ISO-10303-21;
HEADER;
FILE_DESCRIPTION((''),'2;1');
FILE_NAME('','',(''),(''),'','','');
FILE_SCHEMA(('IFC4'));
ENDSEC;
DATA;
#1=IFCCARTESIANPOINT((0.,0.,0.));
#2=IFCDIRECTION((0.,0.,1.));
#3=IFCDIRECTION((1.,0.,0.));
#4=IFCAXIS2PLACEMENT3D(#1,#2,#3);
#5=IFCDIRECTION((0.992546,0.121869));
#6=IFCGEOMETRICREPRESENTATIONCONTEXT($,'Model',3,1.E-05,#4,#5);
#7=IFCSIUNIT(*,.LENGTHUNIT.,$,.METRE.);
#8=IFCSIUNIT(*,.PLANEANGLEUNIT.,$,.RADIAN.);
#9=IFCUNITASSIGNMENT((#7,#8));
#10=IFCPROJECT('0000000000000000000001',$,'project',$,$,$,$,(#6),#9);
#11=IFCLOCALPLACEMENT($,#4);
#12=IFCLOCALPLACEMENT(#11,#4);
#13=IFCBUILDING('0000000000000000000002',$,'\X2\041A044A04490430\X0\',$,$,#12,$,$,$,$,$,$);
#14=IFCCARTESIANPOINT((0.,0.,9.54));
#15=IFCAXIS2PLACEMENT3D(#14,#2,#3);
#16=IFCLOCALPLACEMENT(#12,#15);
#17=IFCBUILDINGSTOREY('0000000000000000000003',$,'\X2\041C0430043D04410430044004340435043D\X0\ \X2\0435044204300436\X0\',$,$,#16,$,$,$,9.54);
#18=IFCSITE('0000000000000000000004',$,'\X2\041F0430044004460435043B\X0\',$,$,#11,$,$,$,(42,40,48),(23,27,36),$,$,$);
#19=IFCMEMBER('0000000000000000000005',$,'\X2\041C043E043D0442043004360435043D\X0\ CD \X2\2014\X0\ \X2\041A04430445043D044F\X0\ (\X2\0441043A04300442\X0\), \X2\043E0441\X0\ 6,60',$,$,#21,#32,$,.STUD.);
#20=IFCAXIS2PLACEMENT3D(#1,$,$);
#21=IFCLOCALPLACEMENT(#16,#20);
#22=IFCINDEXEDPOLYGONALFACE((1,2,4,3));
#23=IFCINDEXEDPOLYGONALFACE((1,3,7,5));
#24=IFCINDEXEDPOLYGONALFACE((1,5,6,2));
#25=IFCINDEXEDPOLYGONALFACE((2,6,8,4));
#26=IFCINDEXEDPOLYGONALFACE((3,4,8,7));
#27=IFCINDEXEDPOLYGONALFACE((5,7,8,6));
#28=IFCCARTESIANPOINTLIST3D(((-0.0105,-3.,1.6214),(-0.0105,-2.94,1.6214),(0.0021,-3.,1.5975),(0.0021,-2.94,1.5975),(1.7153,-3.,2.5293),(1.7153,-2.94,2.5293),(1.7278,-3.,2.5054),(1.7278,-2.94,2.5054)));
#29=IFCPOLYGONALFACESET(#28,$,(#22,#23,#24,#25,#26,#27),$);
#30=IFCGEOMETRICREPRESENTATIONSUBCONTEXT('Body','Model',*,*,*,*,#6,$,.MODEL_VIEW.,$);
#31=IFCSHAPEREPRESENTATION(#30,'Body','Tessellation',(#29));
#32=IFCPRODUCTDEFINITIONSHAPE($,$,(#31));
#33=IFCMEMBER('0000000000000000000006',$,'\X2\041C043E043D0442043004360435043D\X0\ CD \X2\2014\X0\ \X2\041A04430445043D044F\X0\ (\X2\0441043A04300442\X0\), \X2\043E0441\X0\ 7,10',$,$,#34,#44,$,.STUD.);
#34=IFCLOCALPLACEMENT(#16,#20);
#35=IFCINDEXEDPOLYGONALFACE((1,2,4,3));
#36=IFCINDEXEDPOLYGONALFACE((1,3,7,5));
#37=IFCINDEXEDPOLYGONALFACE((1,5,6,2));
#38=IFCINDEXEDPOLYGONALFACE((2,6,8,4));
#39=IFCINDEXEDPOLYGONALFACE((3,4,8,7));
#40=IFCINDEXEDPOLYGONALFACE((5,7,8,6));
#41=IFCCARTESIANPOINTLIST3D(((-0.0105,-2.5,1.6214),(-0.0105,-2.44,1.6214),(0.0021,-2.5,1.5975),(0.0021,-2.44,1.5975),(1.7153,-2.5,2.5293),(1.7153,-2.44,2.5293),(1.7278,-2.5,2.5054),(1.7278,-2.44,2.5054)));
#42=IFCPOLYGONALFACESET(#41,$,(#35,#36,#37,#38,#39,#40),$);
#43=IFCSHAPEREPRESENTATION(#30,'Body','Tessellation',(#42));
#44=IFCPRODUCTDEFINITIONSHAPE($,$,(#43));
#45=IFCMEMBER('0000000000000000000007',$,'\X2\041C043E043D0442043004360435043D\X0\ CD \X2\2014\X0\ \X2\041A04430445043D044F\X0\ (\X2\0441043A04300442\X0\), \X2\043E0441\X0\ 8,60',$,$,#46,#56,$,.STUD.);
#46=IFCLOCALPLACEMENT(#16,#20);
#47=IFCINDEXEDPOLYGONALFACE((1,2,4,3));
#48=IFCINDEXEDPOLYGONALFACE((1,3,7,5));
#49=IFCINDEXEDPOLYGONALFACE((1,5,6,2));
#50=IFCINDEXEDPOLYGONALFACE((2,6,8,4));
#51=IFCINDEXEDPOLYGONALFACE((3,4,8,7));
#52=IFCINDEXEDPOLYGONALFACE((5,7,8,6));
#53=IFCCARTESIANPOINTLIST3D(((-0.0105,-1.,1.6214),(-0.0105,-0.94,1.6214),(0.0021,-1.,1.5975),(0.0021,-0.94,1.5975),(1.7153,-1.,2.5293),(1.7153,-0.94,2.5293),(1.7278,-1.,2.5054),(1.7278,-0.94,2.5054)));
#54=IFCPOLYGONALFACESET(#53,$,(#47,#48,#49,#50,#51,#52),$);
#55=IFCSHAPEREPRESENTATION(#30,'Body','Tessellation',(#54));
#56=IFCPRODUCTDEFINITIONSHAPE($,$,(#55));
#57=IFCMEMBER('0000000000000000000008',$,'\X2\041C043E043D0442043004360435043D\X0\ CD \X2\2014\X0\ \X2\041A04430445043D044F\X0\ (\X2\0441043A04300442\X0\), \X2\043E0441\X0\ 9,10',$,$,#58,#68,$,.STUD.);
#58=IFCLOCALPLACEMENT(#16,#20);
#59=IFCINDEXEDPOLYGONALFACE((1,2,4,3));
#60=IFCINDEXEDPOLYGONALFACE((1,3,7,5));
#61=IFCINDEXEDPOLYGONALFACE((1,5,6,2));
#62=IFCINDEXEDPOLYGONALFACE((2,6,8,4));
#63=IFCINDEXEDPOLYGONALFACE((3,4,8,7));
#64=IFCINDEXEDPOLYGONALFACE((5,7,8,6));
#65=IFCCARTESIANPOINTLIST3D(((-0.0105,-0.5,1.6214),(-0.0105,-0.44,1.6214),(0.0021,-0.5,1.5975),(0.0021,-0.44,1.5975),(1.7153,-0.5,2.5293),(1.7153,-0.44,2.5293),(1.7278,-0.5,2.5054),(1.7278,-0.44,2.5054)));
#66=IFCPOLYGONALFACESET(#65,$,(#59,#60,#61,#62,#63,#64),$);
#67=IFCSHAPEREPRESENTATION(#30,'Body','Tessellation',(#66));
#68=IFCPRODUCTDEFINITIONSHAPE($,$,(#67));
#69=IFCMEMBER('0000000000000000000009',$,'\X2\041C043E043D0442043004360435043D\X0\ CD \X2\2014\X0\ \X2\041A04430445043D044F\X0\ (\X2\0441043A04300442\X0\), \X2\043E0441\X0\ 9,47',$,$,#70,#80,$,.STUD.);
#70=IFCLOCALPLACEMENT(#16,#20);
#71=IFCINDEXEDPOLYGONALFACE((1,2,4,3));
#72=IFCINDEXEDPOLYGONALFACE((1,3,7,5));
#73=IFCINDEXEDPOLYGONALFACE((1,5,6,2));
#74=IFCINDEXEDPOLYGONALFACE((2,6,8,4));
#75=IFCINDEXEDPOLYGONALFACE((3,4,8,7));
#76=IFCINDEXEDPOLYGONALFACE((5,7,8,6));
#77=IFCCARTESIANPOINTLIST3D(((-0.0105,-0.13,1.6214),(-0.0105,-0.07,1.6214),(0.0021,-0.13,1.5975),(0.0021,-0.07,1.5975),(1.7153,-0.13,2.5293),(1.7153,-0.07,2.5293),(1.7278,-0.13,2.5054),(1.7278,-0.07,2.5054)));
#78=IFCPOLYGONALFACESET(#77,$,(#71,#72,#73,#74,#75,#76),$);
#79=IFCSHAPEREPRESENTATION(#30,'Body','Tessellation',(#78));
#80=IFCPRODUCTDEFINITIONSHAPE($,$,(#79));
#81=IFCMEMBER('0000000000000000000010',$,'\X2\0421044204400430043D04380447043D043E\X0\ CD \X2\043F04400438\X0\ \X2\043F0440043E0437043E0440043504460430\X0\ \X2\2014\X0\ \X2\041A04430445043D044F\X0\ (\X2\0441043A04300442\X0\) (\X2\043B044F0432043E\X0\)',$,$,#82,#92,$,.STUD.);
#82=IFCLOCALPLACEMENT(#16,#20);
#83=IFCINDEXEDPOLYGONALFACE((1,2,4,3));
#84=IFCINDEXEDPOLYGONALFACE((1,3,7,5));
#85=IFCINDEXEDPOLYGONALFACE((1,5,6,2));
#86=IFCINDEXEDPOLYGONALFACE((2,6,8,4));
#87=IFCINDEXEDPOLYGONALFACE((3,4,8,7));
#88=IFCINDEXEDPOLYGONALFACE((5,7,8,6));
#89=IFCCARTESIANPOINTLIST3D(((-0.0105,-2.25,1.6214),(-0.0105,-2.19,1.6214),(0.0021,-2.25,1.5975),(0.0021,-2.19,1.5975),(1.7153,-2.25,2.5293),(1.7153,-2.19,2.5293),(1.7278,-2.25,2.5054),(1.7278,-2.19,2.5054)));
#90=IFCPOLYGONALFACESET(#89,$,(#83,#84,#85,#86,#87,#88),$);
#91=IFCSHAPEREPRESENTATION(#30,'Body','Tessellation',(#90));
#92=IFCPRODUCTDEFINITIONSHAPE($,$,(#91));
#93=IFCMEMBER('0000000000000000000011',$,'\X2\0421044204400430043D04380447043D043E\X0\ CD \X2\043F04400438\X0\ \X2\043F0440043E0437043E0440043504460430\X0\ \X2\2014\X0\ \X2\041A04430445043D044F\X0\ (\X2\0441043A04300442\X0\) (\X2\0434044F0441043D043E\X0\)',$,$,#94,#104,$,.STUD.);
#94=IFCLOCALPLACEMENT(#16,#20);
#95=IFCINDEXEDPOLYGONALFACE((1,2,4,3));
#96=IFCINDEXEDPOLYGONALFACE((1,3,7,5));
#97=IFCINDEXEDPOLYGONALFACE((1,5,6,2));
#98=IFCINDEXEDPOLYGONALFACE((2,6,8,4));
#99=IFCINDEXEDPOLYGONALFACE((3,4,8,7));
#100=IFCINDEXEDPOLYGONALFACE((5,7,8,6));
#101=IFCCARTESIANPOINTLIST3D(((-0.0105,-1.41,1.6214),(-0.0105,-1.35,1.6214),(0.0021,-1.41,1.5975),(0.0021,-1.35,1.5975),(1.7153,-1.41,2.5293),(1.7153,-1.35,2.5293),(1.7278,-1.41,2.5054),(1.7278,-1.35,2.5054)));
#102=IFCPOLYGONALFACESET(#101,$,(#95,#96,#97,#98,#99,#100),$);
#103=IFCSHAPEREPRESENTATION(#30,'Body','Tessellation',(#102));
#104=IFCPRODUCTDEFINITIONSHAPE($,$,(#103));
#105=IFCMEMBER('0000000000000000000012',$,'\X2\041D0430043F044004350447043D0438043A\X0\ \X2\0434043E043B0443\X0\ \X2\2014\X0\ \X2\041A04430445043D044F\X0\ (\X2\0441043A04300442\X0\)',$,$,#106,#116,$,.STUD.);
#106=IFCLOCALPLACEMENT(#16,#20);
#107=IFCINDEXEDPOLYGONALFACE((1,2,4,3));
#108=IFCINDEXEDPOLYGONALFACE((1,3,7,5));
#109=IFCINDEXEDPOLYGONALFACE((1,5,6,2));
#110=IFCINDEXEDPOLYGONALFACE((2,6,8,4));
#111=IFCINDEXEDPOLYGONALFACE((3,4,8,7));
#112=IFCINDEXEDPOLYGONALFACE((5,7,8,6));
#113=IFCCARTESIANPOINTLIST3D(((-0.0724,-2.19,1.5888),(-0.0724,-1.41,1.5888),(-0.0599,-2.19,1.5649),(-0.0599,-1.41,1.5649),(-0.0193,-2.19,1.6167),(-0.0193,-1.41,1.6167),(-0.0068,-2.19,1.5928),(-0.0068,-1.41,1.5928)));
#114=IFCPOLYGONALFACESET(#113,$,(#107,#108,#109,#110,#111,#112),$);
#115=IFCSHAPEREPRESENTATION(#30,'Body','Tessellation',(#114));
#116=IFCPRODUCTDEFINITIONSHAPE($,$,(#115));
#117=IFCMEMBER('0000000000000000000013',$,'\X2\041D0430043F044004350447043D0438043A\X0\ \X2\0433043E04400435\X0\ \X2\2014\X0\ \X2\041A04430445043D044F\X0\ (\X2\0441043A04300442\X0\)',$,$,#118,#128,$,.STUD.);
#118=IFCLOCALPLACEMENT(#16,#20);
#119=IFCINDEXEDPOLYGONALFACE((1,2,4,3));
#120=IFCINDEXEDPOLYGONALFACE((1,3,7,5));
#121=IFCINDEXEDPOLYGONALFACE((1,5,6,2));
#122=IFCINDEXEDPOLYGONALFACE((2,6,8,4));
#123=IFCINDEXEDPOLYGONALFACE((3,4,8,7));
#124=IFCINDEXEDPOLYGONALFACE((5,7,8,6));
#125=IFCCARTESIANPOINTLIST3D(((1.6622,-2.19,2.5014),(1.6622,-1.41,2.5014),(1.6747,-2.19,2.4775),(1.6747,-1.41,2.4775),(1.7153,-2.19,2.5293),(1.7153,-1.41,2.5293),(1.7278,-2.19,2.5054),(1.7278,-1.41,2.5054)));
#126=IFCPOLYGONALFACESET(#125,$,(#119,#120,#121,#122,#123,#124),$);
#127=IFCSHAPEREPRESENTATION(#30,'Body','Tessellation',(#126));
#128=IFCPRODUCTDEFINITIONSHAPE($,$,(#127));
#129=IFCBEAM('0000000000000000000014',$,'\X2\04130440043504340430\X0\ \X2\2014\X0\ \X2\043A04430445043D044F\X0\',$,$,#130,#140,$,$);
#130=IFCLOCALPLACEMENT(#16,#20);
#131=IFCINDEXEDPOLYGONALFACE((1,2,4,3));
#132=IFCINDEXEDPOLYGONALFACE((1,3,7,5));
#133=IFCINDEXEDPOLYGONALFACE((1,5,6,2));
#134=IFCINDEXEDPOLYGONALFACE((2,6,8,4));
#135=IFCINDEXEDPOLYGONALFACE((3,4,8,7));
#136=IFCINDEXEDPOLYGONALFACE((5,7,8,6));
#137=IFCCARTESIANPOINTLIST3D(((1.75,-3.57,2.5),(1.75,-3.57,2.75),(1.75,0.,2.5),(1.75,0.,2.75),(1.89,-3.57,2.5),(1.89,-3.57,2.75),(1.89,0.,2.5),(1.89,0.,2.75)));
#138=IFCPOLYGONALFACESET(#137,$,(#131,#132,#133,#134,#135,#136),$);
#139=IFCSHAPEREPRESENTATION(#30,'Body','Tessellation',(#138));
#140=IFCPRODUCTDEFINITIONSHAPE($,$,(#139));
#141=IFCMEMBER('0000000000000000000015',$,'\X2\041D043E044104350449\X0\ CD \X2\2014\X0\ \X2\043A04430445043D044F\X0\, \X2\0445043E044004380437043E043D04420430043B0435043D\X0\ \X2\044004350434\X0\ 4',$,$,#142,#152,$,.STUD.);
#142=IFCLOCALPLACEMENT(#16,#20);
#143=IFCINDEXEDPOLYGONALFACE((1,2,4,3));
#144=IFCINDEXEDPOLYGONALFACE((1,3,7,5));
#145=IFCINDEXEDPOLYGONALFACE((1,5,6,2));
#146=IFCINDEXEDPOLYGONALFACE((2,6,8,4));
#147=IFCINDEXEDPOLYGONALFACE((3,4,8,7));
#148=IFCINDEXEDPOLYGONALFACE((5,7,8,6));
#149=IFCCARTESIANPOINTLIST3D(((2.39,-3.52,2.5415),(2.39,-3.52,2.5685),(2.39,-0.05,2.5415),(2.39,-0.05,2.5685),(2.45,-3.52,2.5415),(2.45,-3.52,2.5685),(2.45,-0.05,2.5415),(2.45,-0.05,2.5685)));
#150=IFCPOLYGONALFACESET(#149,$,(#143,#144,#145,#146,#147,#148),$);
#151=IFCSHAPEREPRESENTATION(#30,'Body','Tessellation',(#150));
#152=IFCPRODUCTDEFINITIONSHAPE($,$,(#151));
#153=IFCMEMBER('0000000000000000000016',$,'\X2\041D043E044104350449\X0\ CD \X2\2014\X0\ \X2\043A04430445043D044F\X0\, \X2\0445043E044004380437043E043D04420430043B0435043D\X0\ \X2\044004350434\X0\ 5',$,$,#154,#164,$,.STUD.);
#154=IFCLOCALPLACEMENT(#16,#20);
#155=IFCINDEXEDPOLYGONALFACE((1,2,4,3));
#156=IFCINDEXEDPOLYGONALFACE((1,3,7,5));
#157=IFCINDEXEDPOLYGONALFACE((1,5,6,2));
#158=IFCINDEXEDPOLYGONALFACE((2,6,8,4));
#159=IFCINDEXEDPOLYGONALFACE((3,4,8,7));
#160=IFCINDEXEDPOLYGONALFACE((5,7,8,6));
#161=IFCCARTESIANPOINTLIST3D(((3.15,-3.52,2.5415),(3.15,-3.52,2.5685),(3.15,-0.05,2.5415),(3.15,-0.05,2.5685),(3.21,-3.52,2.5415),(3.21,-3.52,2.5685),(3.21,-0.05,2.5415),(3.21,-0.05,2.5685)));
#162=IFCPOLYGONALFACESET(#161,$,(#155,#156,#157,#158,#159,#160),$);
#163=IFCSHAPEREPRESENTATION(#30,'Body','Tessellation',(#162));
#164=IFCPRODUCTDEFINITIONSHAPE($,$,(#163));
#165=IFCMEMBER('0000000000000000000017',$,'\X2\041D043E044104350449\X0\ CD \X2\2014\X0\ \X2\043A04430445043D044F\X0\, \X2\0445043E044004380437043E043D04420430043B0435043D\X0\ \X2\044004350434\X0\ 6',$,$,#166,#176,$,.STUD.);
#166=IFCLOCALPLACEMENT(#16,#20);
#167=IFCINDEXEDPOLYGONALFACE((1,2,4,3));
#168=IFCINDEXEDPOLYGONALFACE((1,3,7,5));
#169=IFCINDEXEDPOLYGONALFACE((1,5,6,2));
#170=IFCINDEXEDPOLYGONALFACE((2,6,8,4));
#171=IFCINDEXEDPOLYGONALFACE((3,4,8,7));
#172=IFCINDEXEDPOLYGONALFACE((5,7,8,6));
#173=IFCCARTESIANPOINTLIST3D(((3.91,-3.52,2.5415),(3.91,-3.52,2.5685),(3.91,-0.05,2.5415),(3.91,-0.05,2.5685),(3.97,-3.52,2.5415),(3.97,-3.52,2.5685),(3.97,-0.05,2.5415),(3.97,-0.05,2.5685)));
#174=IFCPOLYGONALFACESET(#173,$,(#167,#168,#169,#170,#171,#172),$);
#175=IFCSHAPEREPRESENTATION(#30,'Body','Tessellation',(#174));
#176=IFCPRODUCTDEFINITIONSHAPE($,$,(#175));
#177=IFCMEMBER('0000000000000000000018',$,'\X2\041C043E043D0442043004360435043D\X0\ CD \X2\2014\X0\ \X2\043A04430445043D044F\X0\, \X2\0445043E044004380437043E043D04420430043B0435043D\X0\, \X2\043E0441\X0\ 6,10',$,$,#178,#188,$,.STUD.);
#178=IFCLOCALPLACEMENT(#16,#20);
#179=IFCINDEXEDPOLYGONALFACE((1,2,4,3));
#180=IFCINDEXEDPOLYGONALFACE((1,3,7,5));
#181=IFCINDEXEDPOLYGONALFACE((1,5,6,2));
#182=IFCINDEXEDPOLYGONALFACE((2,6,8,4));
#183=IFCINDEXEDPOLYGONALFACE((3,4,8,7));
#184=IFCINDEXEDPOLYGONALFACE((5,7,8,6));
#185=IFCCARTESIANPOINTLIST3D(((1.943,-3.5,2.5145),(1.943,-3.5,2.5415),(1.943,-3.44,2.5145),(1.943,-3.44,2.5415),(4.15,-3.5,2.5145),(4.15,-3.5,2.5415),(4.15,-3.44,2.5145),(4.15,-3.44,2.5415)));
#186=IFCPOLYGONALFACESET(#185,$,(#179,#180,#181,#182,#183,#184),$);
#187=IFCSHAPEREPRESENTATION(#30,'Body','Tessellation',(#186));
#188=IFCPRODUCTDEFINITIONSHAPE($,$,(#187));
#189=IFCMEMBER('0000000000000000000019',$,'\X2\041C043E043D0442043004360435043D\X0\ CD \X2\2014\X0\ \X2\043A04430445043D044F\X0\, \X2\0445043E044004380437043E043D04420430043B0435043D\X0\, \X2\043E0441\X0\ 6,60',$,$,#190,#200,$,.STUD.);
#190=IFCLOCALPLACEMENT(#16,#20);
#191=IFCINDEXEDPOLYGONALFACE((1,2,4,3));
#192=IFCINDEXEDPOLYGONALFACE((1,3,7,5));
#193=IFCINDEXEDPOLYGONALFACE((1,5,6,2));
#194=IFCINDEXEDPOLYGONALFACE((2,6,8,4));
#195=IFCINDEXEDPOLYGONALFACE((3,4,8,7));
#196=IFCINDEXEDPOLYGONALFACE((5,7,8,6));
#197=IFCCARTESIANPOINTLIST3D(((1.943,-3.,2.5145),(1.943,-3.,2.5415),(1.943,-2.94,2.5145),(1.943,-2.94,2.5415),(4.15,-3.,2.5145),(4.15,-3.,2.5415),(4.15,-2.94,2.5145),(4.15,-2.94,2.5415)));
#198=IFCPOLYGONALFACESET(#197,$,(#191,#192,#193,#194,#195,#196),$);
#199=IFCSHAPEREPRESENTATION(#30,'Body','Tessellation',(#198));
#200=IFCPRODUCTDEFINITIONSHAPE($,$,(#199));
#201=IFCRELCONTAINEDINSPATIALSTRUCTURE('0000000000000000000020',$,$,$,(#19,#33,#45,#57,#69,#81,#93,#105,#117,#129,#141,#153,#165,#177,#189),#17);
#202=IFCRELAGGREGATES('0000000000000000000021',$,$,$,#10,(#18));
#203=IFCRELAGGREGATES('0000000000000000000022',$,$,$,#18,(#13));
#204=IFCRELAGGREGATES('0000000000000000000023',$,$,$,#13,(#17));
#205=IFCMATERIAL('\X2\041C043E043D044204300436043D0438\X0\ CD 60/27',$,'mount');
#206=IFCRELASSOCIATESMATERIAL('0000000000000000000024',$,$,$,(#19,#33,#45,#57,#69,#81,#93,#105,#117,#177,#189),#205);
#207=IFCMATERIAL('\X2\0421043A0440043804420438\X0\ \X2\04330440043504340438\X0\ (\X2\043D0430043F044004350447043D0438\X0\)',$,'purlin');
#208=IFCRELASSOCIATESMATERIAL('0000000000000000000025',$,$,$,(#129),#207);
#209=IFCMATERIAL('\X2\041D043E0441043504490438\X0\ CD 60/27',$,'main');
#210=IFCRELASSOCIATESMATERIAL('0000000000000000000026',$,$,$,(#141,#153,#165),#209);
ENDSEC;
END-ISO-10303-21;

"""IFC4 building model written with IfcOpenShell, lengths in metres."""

from ifc_helpers import new_model, si_unit, direction, frame, origin_with_axes, place, context, subcontext, project, spatial, polyline, outline, extrude, material, element, save


model = new_model("IFC4")

# Units and contexts
model_context = context("Model", 3, precision=1e-05, world=origin_with_axes(), true_north=direction((0.992546, 0.121869)))
body_context = subcontext(model_context, "Body", "Model", "MODEL_VIEW")
ifc_project = project(units=[si_unit("LENGTHUNIT", "METRE"), si_unit("PLANEANGLEUNIT", "RADIAN")], contexts=[model_context])

# Site, building, storey
site_placement = place(None, origin_with_axes())
site = spatial("IfcSite", under=ifc_project, at=site_placement, Name="Парцел", RefLatitude=(42, 40, 48), RefLongitude=(23, 27, 36))
building_placement = place(site_placement, origin_with_axes())
building = spatial("IfcBuilding", under=site, at=building_placement, Name="Къща")
storey_placement = place(building_placement, frame((0.0, 0.0, 9.54), z_axis=(0.0, 0.0, 1.0), x_axis=(1.0, 0.0, 0.0)))
storey = spatial("IfcBuildingStorey", under=building, at=storey_placement, Name="Мансарден етаж", Elevation=9.54)

# Members
ifc_material_1 = material(Name="Монтажни CD 60/27", Category="mount")
member_1_placement = place(storey_placement, origin_with_axes())
element("IfcMember", 1, at=member_1_placement, inside=storey, material=ifc_material_1, Name="Монтажен CD — Кухня (скат), ос 6,60", PredefinedType="STUD", context=body_context, shape_type="SweptSolid", body=[
    extrude(outline(polyline([(0.0021, -1.5975), (1.7278, -2.5054), (1.7153, -2.5293), (-0.0105, -1.6214), (0.0021, -1.5975)])), frame((0.0, -3.0, 0.0), z_axis=(0.0, 1.0, 0.0), x_axis=(1.0, 0.0, 0.0)), (0.0, 0.0, 1.0), 0.06),
])
member_2_placement = place(storey_placement, origin_with_axes())
element("IfcMember", 2, at=member_2_placement, inside=storey, material=ifc_material_1, Name="Монтажен CD — Кухня (скат), ос 7,10", PredefinedType="STUD", context=body_context, shape_type="SweptSolid", body=[
    extrude(outline(polyline([(0.0021, -1.5975), (1.7278, -2.5054), (1.7153, -2.5293), (-0.0105, -1.6214), (0.0021, -1.5975)])), frame((0.0, -2.5, 0.0), z_axis=(0.0, 1.0, 0.0), x_axis=(1.0, 0.0, 0.0)), (0.0, 0.0, 1.0), 0.06),
])
member_3_placement = place(storey_placement, origin_with_axes())
element("IfcMember", 3, at=member_3_placement, inside=storey, material=ifc_material_1, Name="Монтажен CD — Кухня (скат), ос 8,60", PredefinedType="STUD", context=body_context, shape_type="SweptSolid", body=[
    extrude(outline(polyline([(0.0021, -1.5975), (1.7278, -2.5054), (1.7153, -2.5293), (-0.0105, -1.6214), (0.0021, -1.5975)])), frame((0.0, -1.0, 0.0), z_axis=(0.0, 1.0, 0.0), x_axis=(1.0, 0.0, 0.0)), (0.0, 0.0, 1.0), 0.06),
])
member_4_placement = place(storey_placement, origin_with_axes())
element("IfcMember", 4, at=member_4_placement, inside=storey, material=ifc_material_1, Name="Монтажен CD — Кухня (скат), ос 9,10", PredefinedType="STUD", context=body_context, shape_type="SweptSolid", body=[
    extrude(outline(polyline([(0.0021, -1.5975), (1.7278, -2.5054), (1.7153, -2.5293), (-0.0105, -1.6214), (0.0021, -1.5975)])), frame((0.0, -0.5, 0.0), z_axis=(0.0, 1.0, 0.0), x_axis=(1.0, 0.0, 0.0)), (0.0, 0.0, 1.0), 0.06),
])
member_5_placement = place(storey_placement, origin_with_axes())
element("IfcMember", 5, at=member_5_placement, inside=storey, material=ifc_material_1, Name="Монтажен CD — Кухня (скат), ос 9,47", PredefinedType="STUD", context=body_context, shape_type="SweptSolid", body=[
    extrude(outline(polyline([(0.0021, -1.5975), (1.7278, -2.5054), (1.7153, -2.5293), (-0.0105, -1.6214), (0.0021, -1.5975)])), frame((0.0, -0.13, 0.0), z_axis=(0.0, 1.0, 0.0), x_axis=(1.0, 0.0, 0.0)), (0.0, 0.0, 1.0), 0.06),
])
member_6_placement = place(storey_placement, origin_with_axes())
element("IfcMember", 6, at=member_6_placement, inside=storey, material=ifc_material_1, Name="Странично CD при прозореца — Кухня (скат) (ляво)", PredefinedType="STUD", context=body_context, shape_type="SweptSolid", body=[
    extrude(outline(polyline([(0.0021, -1.5975), (1.7278, -2.5054), (1.7153, -2.5293), (-0.0105, -1.6214), (0.0021, -1.5975)])), frame((0.0, -2.25, 0.0), z_axis=(0.0, 1.0, 0.0), x_axis=(1.0, 0.0, 0.0)), (0.0, 0.0, 1.0), 0.06),
])
member_7_placement = place(storey_placement, origin_with_axes())
element("IfcMember", 7, at=member_7_placement, inside=storey, material=ifc_material_1, Name="Странично CD при прозореца — Кухня (скат) (дясно)", PredefinedType="STUD", context=body_context, shape_type="SweptSolid", body=[
    extrude(outline(polyline([(0.0021, -1.5975), (1.7278, -2.5054), (1.7153, -2.5293), (-0.0105, -1.6214), (0.0021, -1.5975)])), frame((0.0, -1.41, 0.0), z_axis=(0.0, 1.0, 0.0), x_axis=(1.0, 0.0, 0.0)), (0.0, 0.0, 1.0), 0.06),
])
member_8_placement = place(storey_placement, origin_with_axes())
element("IfcMember", 8, at=member_8_placement, inside=storey, material=ifc_material_1, Name="Напречник долу — Кухня (скат)", PredefinedType="STUD", context=body_context, shape_type="SweptSolid", body=[
    extrude(outline(polyline([(-0.0599, -1.5649), (-0.0068, -1.5928), (-0.0193, -1.6167), (-0.0724, -1.5888), (-0.0599, -1.5649)])), frame((0.0, -2.19, 0.0), z_axis=(0.0, 1.0, 0.0), x_axis=(1.0, 0.0, 0.0)), (0.0, 0.0, 1.0), 0.78),
])
member_9_placement = place(storey_placement, origin_with_axes())
element("IfcMember", 9, at=member_9_placement, inside=storey, material=ifc_material_1, Name="Напречник горе — Кухня (скат)", PredefinedType="STUD", context=body_context, shape_type="SweptSolid", body=[
    extrude(outline(polyline([(1.6747, -2.4775), (1.7278, -2.5054), (1.7153, -2.5293), (1.6622, -2.5014), (1.6747, -2.4775)])), frame((0.0, -2.19, 0.0), z_axis=(0.0, 1.0, 0.0), x_axis=(1.0, 0.0, 0.0)), (0.0, 0.0, 1.0), 0.78),
])

# Beam
ifc_material_2 = material(Name="Скрити греди (напречни)", Category="purlin")
beam_placement = place(storey_placement, origin_with_axes())
element("IfcBeam", 10, at=beam_placement, inside=storey, material=ifc_material_2, Name="Греда — кухня", context=body_context, shape_type="SweptSolid", body=[
    extrude(outline(polyline([(1.75, -2.5), (1.89, -2.5), (1.89, -2.75), (1.75, -2.75), (1.75, -2.5)])), frame((0.0, -3.57, 0.0), z_axis=(0.0, 1.0, 0.0), x_axis=(1.0, 0.0, 0.0)), (0.0, 0.0, 1.0), 3.57),
])

# Members
ifc_material_3 = material(Name="Носещи CD 60/27", Category="main")
member_10_placement = place(storey_placement, origin_with_axes())
element("IfcMember", 11, at=member_10_placement, inside=storey, material=ifc_material_3, Name="Носещ CD — кухня, хоризонтален ред 4", PredefinedType="STUD", context=body_context, shape_type="SweptSolid", body=[
    extrude(outline(polyline([(2.39, -2.5415), (2.45, -2.5415), (2.45, -2.5685), (2.39, -2.5685), (2.39, -2.5415)])), frame((0.0, -3.52, 0.0), z_axis=(0.0, 1.0, 0.0), x_axis=(1.0, 0.0, 0.0)), (0.0, 0.0, 1.0), 3.47),
])
member_11_placement = place(storey_placement, origin_with_axes())
element("IfcMember", 12, at=member_11_placement, inside=storey, material=ifc_material_3, Name="Носещ CD — кухня, хоризонтален ред 5", PredefinedType="STUD", context=body_context, shape_type="SweptSolid", body=[
    extrude(outline(polyline([(3.15, -2.5415), (3.21, -2.5415), (3.21, -2.5685), (3.15, -2.5685), (3.15, -2.5415)])), frame((0.0, -3.52, 0.0), z_axis=(0.0, 1.0, 0.0), x_axis=(1.0, 0.0, 0.0)), (0.0, 0.0, 1.0), 3.47),
])
member_12_placement = place(storey_placement, origin_with_axes())
element("IfcMember", 13, at=member_12_placement, inside=storey, material=ifc_material_3, Name="Носещ CD — кухня, хоризонтален ред 6", PredefinedType="STUD", context=body_context, shape_type="SweptSolid", body=[
    extrude(outline(polyline([(3.91, -2.5415), (3.97, -2.5415), (3.97, -2.5685), (3.91, -2.5685), (3.91, -2.5415)])), frame((0.0, -3.52, 0.0), z_axis=(0.0, 1.0, 0.0), x_axis=(1.0, 0.0, 0.0)), (0.0, 0.0, 1.0), 3.47),
])
member_13_placement = place(storey_placement, origin_with_axes())
element("IfcMember", 14, at=member_13_placement, inside=storey, material=ifc_material_1, Name="Монтажен CD — кухня, хоризонтален, ос 6,10", PredefinedType="STUD", context=body_context, shape_type="SweptSolid", body=[
    extrude(outline(polyline([(1.943, -2.5145), (4.15, -2.5145), (4.15, -2.5415), (1.943, -2.5415), (1.943, -2.5145)])), frame((0.0, -3.5, 0.0), z_axis=(0.0, 1.0, 0.0), x_axis=(1.0, 0.0, 0.0)), (0.0, 0.0, 1.0), 0.06),
])
member_14_placement = place(storey_placement, origin_with_axes())
element("IfcMember", 15, at=member_14_placement, inside=storey, material=ifc_material_1, Name="Монтажен CD — кухня, хоризонтален, ос 6,60", PredefinedType="STUD", context=body_context, shape_type="SweptSolid", body=[
    extrude(outline(polyline([(1.943, -2.5145), (4.15, -2.5145), (4.15, -2.5415), (1.943, -2.5415), (1.943, -2.5145)])), frame((0.0, -3.0, 0.0), z_axis=(0.0, 1.0, 0.0), x_axis=(1.0, 0.0, 0.0)), (0.0, 0.0, 1.0), 0.06),
])

save(model, "model.ifc")
